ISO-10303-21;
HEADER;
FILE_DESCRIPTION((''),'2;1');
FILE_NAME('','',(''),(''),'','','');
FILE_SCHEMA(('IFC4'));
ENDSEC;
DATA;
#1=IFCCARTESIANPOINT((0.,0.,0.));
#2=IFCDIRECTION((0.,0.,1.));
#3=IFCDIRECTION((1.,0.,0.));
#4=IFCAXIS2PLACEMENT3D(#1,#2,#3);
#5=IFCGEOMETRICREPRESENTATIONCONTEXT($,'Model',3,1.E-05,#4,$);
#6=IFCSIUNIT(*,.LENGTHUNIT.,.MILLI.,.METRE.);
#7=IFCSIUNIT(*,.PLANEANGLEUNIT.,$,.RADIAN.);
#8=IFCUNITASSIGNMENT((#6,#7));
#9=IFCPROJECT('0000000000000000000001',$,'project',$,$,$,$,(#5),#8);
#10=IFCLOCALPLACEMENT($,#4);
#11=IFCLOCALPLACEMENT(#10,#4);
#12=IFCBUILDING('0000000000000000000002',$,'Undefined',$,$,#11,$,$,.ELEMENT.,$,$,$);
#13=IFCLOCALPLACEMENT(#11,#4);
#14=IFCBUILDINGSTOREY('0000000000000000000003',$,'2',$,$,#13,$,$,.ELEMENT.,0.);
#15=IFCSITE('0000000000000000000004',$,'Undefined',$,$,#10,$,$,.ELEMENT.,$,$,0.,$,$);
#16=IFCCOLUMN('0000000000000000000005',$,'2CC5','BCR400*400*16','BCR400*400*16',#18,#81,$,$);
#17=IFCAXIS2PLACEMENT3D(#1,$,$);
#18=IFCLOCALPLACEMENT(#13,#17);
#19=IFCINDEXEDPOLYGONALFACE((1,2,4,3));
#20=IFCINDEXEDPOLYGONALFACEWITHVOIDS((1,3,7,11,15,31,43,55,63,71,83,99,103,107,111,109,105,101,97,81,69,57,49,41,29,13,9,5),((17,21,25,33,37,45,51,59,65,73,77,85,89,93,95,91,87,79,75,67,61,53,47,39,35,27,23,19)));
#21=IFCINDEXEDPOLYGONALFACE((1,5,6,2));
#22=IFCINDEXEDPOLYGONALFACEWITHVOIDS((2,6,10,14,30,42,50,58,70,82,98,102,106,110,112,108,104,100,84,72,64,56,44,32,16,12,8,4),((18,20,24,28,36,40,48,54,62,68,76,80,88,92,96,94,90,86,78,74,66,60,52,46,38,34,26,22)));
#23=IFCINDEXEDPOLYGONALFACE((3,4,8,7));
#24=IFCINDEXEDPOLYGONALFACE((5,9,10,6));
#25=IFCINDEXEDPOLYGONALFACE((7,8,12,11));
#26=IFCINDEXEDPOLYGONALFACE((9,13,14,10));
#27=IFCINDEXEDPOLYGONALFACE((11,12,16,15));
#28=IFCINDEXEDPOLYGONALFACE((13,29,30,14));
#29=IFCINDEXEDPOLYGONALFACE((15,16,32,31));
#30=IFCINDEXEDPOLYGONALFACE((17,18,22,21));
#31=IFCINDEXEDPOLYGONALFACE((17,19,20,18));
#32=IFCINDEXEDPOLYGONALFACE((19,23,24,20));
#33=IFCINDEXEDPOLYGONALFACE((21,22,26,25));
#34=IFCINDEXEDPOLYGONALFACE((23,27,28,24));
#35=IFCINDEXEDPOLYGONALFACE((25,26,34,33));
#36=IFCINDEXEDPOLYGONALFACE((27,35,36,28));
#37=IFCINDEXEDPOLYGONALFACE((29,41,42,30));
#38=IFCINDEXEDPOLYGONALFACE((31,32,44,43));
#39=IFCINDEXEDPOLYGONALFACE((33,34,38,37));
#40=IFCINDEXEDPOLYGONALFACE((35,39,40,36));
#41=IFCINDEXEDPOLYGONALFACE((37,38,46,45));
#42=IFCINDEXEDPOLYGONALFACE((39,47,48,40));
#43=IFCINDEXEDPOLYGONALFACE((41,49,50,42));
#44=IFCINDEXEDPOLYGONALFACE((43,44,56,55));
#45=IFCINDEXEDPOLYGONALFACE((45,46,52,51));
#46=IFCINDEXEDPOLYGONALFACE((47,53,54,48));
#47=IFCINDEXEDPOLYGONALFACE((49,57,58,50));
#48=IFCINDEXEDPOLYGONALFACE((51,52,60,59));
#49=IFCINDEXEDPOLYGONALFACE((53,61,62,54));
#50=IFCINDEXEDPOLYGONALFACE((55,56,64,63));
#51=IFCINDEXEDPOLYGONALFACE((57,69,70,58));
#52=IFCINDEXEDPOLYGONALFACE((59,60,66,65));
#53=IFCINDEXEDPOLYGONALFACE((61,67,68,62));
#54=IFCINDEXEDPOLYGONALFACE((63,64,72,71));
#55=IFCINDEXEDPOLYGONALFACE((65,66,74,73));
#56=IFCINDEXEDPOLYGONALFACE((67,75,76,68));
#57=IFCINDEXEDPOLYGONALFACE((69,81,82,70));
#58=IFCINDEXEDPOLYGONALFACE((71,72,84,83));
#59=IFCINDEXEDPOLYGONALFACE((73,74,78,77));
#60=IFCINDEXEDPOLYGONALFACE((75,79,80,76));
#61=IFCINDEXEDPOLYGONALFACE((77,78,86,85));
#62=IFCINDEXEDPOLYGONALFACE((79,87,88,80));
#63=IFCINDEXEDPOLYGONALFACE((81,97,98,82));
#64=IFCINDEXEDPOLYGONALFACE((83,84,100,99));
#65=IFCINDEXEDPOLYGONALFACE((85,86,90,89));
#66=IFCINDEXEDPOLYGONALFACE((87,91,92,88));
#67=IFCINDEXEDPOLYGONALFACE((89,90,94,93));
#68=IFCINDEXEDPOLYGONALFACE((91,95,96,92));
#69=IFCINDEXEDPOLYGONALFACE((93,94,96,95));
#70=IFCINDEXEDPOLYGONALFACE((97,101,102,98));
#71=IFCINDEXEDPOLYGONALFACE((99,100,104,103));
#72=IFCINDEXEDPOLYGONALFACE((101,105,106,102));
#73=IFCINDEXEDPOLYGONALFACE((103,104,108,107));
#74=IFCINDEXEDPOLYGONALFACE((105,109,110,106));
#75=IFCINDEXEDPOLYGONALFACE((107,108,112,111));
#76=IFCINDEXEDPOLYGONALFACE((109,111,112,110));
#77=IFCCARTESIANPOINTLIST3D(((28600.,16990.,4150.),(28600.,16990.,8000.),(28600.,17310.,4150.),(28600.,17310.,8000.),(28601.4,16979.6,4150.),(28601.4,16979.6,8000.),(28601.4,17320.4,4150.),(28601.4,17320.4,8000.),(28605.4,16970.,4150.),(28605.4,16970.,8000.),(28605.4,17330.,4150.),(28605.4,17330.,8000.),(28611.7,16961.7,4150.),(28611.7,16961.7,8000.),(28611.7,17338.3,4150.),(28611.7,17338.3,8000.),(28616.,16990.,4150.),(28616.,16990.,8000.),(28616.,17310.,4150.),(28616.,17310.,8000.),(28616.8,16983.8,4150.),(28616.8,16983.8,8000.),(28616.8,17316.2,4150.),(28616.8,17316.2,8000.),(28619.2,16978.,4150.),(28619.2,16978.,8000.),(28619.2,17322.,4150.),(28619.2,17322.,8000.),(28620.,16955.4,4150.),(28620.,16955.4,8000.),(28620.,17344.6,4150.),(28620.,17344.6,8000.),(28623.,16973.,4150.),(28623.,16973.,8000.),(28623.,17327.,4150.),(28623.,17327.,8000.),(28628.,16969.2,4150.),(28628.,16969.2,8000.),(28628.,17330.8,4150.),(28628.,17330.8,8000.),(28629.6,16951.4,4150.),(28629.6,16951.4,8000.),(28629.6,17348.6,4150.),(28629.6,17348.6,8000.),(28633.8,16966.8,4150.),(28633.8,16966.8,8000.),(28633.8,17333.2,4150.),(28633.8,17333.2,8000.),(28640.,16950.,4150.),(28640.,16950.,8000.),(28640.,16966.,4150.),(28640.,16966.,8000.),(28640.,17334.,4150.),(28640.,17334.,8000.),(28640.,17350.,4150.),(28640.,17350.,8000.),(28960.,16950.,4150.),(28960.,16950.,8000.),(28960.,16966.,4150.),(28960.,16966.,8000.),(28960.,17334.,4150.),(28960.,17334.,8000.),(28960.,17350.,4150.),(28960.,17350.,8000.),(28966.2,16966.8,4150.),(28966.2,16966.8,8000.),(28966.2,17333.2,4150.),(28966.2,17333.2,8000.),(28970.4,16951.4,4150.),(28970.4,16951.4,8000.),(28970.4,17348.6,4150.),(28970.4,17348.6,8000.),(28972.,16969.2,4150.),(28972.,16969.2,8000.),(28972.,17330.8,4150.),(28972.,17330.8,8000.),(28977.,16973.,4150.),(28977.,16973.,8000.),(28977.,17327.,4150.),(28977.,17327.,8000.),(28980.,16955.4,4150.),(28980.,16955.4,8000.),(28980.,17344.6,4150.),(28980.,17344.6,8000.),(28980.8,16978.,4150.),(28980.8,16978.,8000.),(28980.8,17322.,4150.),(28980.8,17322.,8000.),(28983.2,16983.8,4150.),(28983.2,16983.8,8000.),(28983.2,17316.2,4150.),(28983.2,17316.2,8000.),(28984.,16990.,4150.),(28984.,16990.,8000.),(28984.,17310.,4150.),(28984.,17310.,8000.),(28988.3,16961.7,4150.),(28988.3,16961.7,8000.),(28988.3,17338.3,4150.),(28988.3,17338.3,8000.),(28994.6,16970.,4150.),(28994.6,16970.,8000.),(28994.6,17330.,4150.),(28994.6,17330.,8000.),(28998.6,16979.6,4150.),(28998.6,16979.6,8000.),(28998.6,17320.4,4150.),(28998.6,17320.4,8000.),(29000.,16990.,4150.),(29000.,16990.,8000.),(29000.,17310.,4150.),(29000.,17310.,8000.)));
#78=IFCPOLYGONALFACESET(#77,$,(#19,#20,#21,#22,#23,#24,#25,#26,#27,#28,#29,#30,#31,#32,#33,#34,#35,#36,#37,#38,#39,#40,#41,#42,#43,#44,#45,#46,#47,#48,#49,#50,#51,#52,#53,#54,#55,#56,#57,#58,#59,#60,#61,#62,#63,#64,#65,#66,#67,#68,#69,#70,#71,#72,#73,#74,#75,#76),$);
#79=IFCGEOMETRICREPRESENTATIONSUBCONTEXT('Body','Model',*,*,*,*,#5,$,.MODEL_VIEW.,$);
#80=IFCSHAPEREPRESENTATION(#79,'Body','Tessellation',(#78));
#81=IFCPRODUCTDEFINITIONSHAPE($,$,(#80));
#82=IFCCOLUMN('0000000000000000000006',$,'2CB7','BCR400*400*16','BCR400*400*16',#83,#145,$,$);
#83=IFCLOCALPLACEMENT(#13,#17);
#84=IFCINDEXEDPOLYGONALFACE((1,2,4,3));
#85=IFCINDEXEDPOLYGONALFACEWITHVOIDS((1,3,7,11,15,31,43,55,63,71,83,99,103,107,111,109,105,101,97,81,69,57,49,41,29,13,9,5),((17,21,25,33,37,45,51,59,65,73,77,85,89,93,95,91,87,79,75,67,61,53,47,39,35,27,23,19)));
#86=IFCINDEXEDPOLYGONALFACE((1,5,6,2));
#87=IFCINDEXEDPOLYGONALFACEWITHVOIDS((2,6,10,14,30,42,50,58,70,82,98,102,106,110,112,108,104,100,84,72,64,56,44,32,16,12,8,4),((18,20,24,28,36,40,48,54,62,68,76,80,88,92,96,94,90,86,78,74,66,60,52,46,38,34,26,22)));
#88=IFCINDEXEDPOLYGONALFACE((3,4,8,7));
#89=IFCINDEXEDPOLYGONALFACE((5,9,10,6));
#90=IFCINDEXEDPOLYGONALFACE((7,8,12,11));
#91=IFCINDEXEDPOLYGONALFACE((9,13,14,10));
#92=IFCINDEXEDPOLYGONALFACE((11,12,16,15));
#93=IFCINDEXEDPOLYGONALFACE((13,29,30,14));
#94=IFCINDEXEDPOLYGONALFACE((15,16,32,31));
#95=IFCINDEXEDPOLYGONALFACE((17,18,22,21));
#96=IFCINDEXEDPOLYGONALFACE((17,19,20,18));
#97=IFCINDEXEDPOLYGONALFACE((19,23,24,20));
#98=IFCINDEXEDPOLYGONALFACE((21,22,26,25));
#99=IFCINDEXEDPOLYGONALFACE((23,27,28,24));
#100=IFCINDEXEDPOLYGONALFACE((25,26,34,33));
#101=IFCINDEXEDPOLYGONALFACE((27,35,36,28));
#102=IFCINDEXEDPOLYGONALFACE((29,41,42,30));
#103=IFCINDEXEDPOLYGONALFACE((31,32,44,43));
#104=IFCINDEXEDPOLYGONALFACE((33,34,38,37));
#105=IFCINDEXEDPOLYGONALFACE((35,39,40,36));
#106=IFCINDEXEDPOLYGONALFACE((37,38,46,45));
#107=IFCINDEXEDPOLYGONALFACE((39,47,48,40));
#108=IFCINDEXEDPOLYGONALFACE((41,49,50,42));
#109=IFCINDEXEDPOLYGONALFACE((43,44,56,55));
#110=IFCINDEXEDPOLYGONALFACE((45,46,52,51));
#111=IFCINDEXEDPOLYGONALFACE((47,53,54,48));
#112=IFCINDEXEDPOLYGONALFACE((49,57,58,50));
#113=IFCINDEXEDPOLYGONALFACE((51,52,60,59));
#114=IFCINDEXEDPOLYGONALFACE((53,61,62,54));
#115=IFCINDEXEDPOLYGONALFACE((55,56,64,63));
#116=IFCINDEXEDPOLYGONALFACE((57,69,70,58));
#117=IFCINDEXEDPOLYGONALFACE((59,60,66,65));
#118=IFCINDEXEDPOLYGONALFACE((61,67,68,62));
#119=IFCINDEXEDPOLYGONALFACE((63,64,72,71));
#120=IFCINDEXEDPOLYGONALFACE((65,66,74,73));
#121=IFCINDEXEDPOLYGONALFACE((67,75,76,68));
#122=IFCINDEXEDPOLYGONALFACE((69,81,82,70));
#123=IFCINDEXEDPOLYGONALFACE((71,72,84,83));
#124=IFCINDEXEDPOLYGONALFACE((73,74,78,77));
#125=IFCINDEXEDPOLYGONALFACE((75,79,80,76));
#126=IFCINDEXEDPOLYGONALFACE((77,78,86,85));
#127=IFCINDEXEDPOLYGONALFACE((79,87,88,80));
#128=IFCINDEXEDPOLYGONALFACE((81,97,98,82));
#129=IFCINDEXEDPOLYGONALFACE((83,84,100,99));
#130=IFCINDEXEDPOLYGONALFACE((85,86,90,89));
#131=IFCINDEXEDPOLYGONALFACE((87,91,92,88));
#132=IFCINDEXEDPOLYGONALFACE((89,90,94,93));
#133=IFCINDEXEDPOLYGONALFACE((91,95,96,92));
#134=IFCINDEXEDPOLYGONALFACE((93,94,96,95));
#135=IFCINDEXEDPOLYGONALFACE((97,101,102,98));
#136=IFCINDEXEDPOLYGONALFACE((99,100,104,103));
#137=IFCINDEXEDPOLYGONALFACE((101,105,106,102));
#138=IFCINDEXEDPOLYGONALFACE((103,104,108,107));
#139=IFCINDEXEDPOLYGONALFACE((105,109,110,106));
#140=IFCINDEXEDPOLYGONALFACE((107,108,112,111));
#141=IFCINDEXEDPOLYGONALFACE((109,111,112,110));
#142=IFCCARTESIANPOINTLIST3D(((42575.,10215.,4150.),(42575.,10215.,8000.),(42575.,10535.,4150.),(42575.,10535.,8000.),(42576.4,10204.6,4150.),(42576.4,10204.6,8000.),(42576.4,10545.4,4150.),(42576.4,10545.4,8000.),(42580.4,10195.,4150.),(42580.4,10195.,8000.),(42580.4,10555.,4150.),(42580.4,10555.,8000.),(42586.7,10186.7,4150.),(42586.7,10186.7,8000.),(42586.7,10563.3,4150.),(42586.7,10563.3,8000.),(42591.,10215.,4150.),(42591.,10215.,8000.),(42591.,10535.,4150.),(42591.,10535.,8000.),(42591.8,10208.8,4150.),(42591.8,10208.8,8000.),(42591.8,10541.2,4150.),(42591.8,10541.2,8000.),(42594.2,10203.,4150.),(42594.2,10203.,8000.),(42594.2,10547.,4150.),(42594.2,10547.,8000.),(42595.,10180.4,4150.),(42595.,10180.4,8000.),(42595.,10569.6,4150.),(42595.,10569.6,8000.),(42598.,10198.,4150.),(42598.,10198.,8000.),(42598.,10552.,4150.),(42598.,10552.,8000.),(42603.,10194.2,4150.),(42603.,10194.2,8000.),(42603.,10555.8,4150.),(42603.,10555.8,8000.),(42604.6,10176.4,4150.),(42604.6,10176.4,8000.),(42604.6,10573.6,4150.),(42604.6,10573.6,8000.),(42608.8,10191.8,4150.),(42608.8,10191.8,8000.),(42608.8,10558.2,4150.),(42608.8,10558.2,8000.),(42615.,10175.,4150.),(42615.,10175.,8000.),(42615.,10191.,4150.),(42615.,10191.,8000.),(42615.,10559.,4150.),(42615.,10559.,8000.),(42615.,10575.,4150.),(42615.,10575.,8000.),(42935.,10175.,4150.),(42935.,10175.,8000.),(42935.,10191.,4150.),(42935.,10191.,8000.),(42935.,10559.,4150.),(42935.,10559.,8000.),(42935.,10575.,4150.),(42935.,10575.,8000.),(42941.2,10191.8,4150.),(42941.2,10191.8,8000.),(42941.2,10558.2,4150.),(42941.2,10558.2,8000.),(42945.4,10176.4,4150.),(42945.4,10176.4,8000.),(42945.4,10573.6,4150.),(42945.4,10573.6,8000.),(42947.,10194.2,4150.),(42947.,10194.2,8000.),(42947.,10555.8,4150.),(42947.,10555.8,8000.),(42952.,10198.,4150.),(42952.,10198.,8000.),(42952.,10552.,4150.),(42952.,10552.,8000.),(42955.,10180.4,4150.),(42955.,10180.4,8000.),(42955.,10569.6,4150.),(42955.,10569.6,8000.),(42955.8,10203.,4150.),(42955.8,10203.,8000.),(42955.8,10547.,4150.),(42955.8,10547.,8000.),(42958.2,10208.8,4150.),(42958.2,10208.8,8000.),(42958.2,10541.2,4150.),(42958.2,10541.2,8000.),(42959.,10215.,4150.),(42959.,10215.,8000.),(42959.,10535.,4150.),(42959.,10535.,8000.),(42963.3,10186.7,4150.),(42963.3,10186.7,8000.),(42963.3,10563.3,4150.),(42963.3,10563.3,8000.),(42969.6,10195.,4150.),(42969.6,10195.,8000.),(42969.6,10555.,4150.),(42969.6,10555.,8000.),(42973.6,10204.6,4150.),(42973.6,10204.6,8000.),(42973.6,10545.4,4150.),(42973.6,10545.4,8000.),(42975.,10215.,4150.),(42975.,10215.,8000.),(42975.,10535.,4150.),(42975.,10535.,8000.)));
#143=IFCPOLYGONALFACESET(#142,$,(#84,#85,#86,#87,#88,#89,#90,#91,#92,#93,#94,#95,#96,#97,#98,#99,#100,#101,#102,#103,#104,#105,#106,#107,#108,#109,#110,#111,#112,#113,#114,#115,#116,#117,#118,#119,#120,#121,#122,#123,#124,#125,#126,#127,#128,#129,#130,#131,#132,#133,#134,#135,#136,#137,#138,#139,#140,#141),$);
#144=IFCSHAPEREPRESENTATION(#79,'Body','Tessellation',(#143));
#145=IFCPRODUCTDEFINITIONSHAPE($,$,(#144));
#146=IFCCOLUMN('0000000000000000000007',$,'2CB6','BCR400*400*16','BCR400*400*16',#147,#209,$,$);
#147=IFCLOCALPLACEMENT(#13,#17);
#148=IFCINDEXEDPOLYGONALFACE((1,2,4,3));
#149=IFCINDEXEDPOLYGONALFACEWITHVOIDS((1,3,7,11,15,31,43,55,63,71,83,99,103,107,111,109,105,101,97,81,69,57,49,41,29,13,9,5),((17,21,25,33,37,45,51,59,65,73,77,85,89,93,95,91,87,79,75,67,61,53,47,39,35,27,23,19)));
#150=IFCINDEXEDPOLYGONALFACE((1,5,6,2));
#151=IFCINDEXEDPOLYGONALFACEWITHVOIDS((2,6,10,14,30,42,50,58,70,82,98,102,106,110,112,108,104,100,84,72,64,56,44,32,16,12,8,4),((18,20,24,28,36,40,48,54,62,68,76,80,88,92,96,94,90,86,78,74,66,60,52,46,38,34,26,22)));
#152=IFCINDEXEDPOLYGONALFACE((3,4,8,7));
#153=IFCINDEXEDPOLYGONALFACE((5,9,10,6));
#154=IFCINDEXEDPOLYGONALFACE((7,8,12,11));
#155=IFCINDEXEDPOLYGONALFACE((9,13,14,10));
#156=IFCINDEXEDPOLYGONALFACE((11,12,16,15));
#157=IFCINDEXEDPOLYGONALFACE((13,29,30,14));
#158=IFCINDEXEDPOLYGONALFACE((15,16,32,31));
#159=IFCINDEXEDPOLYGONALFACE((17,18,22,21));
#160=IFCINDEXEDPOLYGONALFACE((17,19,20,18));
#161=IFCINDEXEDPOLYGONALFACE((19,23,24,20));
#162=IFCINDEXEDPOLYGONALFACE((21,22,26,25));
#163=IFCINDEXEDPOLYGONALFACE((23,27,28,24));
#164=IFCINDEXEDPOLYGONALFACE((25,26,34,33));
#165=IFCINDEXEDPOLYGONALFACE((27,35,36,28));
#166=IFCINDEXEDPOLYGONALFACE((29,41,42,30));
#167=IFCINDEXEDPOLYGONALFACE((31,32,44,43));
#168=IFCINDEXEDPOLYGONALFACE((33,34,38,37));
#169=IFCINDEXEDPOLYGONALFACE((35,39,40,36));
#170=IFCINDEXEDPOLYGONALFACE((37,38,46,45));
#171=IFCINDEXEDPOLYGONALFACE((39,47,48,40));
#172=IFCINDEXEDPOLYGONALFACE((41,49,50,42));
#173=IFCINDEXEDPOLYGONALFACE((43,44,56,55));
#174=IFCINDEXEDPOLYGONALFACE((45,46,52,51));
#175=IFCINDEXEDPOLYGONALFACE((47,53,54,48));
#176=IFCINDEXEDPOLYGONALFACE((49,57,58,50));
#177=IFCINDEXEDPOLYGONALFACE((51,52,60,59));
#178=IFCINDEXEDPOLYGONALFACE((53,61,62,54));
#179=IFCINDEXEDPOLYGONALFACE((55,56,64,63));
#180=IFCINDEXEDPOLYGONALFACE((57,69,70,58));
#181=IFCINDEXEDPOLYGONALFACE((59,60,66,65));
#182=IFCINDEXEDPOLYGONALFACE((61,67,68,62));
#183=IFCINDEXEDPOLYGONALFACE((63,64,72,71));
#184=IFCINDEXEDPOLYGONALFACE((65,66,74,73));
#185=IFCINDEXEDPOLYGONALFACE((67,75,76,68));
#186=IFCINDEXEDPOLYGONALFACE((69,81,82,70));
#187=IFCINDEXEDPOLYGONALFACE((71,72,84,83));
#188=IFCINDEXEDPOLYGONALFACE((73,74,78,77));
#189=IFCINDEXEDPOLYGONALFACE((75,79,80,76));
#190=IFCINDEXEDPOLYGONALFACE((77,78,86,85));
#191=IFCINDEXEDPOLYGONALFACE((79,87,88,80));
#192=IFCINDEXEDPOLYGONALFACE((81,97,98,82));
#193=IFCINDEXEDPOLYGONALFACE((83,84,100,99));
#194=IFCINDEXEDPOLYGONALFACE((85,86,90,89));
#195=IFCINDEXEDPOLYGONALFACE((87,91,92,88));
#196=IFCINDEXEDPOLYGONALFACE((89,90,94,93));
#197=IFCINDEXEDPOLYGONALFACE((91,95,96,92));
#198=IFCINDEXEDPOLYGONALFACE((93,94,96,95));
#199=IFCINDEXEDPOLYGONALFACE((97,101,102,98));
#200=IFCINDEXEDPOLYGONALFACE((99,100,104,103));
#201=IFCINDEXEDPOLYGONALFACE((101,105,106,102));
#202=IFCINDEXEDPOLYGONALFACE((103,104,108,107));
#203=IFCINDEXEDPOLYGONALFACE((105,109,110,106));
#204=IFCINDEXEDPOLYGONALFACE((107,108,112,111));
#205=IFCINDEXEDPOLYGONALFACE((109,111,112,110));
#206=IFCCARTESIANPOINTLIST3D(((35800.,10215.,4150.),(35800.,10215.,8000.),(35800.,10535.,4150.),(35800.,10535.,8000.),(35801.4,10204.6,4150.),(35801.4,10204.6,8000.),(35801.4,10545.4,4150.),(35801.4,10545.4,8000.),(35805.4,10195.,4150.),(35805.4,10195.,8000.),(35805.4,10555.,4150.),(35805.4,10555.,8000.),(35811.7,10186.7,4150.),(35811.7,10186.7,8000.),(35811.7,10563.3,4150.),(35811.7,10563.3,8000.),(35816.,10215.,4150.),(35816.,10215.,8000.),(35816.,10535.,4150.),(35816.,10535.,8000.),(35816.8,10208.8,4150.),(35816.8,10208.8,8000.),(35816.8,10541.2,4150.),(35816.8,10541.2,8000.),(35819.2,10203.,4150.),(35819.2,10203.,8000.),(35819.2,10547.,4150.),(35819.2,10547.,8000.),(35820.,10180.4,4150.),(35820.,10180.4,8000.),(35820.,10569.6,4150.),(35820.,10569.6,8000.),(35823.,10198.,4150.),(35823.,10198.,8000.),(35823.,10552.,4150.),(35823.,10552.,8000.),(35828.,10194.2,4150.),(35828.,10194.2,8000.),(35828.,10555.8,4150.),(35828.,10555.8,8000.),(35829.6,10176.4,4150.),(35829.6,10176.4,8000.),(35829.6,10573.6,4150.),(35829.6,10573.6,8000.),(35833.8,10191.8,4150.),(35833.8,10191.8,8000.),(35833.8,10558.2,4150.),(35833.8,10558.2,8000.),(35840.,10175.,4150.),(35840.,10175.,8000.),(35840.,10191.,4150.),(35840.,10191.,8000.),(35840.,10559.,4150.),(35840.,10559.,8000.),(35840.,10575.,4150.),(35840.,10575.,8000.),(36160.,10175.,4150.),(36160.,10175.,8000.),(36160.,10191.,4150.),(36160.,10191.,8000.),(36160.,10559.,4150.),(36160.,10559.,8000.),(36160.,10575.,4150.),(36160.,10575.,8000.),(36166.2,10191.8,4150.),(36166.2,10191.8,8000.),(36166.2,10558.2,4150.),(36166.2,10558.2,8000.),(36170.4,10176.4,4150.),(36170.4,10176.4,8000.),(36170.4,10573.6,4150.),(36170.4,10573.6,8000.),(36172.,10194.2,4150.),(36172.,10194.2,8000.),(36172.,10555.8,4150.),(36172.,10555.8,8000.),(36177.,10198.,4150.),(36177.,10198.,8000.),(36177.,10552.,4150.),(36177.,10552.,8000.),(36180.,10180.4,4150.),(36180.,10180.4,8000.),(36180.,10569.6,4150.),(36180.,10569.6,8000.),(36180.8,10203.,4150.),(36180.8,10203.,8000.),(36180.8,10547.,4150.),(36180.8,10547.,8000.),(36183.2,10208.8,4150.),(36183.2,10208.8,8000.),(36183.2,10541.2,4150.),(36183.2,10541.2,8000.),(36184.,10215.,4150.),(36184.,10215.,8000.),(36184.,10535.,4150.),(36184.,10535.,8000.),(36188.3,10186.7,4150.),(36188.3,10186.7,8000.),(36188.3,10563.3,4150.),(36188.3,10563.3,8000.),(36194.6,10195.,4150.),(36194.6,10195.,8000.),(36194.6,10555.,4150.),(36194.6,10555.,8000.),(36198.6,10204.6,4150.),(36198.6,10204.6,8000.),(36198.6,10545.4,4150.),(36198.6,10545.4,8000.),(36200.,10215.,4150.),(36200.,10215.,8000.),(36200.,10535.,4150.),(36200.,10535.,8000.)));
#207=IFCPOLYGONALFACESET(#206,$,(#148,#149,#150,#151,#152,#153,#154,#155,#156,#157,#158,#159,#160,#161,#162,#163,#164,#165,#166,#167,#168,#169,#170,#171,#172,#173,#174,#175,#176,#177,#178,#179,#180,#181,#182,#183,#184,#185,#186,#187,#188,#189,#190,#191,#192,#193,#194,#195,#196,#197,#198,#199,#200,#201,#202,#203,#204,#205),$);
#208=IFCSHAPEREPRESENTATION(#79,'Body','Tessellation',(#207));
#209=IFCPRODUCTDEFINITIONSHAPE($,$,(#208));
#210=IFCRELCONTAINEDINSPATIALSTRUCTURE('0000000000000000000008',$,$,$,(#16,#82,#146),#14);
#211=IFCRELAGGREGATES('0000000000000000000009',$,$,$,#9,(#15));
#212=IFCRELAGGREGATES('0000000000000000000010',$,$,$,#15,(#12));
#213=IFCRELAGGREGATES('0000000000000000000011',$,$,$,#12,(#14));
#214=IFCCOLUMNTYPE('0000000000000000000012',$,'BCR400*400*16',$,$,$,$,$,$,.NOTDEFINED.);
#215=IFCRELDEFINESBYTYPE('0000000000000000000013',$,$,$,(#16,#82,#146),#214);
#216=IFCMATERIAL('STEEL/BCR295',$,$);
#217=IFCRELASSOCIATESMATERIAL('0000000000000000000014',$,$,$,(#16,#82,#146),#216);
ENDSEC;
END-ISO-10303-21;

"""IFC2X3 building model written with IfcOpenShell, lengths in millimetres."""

from ifc_helpers import new_model, si_unit, frame, origin_with_axes, origin_2d_with_axis, place, context, subcontext, project, spatial, hollow_rectangle, extrude, material, type_object, element, save


model = new_model("IFC2X3")

# Units and contexts
model_context = context("Model", 3, precision=1e-05, world=origin_with_axes())
body_context = subcontext(model_context, "Body", "Model", "MODEL_VIEW")
ifc_project = project(units=[si_unit("LENGTHUNIT", "METRE", prefix="MILLI"), si_unit("PLANEANGLEUNIT", "RADIAN")], contexts=[model_context])

# Site, building, storey
site_placement = place(None, origin_with_axes())
site = spatial("IfcSite", under=ifc_project, at=site_placement, Name="Undefined", CompositionType="ELEMENT", RefElevation=0.0)
building_placement = place(site_placement, origin_with_axes())
building = spatial("IfcBuilding", under=site, at=building_placement, Name="Undefined", CompositionType="ELEMENT")
storey_placement = place(building_placement, origin_with_axes())
storey = spatial("IfcBuildingStorey", under=building, at=storey_placement, Name="2", CompositionType="ELEMENT", Elevation=0.0)

# Columns
ifc_material_1 = material(Name="STEEL/BCR295")
column_type_1 = type_object("IfcColumnType", Name="BCR400*400*16", PredefinedType="NOTDEFINED")
for number, where, z_axis, x_axis, name in (
    (1, (28800.0, 17150.0, 4150.0), (0.0, 0.0, 1.0), (0.0, 1.0, 0.0), "2CC5"),
    (2, (42775.0, 10375.0, 4150.0), (0.0, 0.0, 1.0), (0.0, 1.0, 0.0), "2CB7"),
    (3, (36000.0, 10375.0, 4150.0), (0.0, 0.0, 1.0), (0.0, 1.0, 0.0), "2CB6"),
):
    element("IfcColumn", number, at=place(storey_placement, frame(where, z_axis=z_axis, x_axis=x_axis)), inside=storey, type_object=column_type_1, material=ifc_material_1, Name=name, Description="BCR400*400*16", ObjectType="BCR400*400*16", context=body_context, shape_type="SweptSolid", body=[
        extrude(hollow_rectangle(XDim=400.0, YDim=400.0, WallThickness=16.0, InnerFilletRadius=24.0, OuterFilletRadius=40.0, at=origin_2d_with_axis()), frame((0.0, 0.0, 3850.0), z_axis=(0.0, 0.0, -1.0), x_axis=(0.0, 1.0, 0.0)), (0.0, 0.0, 1.0), 3850.0),
    ])

save(model, "model.ifc")
